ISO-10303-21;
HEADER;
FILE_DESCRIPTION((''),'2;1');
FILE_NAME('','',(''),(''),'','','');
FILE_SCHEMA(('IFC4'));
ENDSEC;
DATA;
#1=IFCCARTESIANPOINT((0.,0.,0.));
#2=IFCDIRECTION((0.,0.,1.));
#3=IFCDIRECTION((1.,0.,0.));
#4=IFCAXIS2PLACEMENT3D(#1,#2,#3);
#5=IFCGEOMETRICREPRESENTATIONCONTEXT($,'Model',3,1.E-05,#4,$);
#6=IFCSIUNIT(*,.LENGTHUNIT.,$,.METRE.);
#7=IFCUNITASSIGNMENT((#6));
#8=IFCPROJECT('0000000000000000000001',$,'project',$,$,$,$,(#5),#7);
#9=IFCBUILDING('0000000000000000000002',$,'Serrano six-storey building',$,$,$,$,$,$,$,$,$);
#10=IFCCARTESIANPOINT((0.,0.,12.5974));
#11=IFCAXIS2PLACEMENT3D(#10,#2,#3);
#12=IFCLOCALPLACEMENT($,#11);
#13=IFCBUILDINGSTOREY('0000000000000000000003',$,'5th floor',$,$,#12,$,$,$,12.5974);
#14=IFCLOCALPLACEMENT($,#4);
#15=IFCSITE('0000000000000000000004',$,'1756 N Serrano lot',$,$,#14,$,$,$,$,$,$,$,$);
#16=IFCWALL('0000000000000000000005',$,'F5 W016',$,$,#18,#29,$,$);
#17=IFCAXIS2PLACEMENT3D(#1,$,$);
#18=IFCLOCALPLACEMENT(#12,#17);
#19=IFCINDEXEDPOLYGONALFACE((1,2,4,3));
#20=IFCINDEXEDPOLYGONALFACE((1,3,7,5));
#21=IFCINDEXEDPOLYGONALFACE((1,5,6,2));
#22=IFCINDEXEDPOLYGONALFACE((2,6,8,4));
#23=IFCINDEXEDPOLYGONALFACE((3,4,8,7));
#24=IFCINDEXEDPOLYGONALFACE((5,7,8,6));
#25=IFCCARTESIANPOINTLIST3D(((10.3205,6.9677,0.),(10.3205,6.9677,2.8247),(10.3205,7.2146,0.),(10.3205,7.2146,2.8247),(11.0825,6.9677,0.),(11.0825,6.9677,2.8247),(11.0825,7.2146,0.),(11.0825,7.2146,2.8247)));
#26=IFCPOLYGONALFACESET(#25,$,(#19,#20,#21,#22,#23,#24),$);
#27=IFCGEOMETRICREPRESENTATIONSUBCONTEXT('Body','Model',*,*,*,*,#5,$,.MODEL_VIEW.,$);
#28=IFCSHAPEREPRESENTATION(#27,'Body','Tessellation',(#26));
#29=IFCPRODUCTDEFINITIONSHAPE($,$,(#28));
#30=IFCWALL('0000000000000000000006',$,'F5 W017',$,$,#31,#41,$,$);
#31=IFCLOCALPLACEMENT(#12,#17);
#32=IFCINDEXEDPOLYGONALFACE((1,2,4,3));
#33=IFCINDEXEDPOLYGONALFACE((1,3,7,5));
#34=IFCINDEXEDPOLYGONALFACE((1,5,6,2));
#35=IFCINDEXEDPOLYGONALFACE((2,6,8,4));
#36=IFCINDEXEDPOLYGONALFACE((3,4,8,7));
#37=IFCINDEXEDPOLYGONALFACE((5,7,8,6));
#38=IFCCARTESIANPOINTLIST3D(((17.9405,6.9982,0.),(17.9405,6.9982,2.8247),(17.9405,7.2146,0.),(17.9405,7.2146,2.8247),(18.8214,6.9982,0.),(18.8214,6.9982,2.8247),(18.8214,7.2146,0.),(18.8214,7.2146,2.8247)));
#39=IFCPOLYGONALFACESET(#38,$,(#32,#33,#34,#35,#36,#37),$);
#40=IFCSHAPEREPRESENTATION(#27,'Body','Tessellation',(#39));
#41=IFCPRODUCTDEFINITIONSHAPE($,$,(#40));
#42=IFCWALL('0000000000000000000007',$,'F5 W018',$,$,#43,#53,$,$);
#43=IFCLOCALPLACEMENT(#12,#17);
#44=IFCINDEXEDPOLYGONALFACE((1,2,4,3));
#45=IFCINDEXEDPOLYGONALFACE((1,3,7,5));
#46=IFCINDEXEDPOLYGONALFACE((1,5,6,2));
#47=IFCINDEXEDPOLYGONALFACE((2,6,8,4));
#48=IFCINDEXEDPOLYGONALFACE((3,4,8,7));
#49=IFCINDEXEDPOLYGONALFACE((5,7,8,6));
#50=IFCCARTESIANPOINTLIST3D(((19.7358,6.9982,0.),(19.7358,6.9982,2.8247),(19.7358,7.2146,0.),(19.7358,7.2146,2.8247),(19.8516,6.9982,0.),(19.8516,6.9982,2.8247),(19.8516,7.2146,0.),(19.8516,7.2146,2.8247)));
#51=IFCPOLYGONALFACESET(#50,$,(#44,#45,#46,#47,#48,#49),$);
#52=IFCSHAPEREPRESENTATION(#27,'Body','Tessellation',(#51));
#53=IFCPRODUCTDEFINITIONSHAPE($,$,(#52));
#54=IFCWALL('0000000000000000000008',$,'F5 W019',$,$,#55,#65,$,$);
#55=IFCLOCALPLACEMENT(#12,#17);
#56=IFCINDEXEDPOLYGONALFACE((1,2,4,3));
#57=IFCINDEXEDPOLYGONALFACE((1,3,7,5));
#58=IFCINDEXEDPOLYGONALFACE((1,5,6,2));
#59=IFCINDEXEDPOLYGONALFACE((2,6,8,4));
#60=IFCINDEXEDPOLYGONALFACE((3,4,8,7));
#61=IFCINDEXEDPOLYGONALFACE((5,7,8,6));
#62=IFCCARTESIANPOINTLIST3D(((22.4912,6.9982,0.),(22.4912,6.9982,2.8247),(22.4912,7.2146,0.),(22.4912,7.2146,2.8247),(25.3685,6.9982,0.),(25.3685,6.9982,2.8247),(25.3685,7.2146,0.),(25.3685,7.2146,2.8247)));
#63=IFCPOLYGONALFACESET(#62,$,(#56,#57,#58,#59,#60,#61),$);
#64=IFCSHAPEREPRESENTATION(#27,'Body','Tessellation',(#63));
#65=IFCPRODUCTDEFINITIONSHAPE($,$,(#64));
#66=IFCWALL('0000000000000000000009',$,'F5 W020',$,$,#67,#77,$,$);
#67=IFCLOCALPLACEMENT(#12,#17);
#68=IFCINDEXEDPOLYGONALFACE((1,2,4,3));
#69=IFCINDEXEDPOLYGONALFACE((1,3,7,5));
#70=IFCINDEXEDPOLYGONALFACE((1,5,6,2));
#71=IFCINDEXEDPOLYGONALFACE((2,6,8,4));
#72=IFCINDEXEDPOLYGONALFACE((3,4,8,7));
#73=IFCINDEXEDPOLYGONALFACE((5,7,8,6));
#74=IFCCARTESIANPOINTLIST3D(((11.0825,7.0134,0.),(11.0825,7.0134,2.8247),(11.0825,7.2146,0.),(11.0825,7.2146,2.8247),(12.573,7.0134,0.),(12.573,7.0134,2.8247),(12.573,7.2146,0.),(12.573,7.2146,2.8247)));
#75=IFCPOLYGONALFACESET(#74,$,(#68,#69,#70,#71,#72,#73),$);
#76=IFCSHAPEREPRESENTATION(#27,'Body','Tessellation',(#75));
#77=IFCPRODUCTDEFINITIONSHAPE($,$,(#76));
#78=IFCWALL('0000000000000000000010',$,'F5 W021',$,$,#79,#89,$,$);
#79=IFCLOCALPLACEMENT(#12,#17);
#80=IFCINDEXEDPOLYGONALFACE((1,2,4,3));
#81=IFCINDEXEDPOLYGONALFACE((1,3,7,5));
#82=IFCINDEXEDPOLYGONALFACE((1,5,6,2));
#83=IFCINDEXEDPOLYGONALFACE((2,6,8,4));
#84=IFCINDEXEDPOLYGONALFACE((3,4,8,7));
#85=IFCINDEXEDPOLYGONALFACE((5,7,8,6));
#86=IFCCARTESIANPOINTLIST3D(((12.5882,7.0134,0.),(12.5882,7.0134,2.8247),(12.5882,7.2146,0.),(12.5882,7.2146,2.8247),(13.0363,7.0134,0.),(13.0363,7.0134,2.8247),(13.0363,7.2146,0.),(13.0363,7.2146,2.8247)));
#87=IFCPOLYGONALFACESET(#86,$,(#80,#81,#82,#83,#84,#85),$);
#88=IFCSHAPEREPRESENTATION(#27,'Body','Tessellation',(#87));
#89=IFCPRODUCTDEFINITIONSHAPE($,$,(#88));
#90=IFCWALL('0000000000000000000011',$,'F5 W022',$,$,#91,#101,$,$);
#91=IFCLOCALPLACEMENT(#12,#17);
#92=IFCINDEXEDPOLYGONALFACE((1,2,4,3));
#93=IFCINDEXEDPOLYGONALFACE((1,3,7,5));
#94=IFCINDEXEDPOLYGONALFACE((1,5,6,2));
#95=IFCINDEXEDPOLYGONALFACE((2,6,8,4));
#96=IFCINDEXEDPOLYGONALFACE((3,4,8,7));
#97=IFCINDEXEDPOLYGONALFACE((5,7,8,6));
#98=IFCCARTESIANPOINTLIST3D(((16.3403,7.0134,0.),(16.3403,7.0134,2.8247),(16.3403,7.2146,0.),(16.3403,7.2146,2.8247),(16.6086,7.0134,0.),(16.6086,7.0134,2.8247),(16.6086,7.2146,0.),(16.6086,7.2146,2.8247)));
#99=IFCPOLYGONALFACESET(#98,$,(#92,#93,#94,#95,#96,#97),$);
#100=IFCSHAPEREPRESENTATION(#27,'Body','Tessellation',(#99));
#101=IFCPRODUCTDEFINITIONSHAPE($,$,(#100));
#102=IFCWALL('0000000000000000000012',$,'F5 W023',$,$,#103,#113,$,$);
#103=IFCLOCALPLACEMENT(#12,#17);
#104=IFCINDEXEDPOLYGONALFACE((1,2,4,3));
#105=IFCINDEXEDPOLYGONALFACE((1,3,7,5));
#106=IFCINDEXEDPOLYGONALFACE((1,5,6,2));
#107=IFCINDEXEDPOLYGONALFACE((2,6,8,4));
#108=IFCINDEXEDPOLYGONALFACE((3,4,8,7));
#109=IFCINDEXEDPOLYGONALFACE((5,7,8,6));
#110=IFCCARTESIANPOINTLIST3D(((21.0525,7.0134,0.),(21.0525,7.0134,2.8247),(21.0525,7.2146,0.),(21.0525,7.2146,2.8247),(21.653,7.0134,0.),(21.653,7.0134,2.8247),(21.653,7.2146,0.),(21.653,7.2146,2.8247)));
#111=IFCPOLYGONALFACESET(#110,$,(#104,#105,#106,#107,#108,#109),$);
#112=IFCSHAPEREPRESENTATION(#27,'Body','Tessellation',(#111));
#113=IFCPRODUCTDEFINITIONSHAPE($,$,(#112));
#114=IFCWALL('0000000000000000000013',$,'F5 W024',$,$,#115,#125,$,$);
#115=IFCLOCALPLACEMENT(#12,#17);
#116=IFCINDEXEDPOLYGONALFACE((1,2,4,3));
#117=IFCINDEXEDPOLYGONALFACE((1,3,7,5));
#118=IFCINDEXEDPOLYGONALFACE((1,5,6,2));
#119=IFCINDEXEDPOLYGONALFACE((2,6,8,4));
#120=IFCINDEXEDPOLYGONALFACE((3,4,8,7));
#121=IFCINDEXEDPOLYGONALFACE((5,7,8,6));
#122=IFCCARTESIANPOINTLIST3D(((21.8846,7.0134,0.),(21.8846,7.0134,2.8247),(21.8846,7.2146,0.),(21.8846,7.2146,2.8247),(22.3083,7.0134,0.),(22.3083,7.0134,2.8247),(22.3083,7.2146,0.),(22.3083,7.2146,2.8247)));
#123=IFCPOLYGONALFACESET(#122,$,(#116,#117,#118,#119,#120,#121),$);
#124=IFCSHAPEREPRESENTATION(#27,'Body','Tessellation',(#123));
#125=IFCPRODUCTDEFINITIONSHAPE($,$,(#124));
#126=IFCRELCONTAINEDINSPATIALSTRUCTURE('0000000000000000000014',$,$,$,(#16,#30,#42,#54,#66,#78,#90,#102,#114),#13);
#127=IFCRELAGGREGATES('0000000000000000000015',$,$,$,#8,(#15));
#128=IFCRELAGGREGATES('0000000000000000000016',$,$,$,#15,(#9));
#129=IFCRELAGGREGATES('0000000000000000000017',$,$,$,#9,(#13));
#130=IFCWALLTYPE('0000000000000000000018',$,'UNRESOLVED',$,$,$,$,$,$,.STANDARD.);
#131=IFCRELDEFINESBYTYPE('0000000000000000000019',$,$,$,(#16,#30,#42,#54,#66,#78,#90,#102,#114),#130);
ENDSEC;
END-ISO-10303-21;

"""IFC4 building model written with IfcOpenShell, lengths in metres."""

from ifc_helpers import new_model, si_unit, frame, origin_with_axes, place, context, subcontext, project, spatial, polyline, outline, extrude, type_object, element, save


model = new_model("IFC4")

# Units and contexts
model_context = context("Model", 3, precision=1e-05, world=origin_with_axes())
body_context = subcontext(model_context, "Body", "Model", "MODEL_VIEW")
ifc_project = project(units=[si_unit("LENGTHUNIT", "METRE")], contexts=[model_context])

# Site, building, storey
site_placement = place(None, origin_with_axes())
site = spatial("IfcSite", under=ifc_project, at=site_placement, Name="1756 N Serrano lot")
building = spatial("IfcBuilding", under=site, Name="Serrano six-storey building")
storey_placement = place(None, frame((0.0, 0.0, 12.5974), z_axis=(0.0, 0.0, 1.0), x_axis=(1.0, 0.0, 0.0)))
storey = spatial("IfcBuildingStorey", under=building, at=storey_placement, Name="5th floor", Elevation=12.5974)

# Walls
wall_type = type_object("IfcWallType", Name="UNRESOLVED", PredefinedType="STANDARD")
wall_1_placement = place(storey_placement, frame((0.0, 0.0, -12.5974), z_axis=(0.0, 0.0, 1.0), x_axis=(1.0, 0.0, 0.0)))
element("IfcWall", 1, at=wall_1_placement, inside=storey, type_object=wall_type, Name="F5 W016", context=body_context, shape_type="SweptSolid", body=[
    extrude(outline(polyline([(11.0825, 7.2146), (11.0825, 6.9677), (10.3205, 6.9677), (10.3205, 7.2146), (11.0825, 7.2146)])), frame((0.0, 0.0, 12.5974)), (0.0, 0.0, 1.0), 2.8247),
])
wall_2_placement = place(storey_placement, frame((0.0, 0.0, -12.5974), z_axis=(0.0, 0.0, 1.0), x_axis=(1.0, 0.0, 0.0)))
element("IfcWall", 2, at=wall_2_placement, inside=storey, type_object=wall_type, Name="F5 W017", context=body_context, shape_type="SweptSolid", body=[
    extrude(outline(polyline([(18.8214, 7.2146), (18.8214, 6.9982), (17.9405, 6.9982), (17.9405, 7.2146), (18.8214, 7.2146)])), frame((0.0, 0.0, 12.5974)), (0.0, 0.0, 1.0), 2.8247),
])
wall_3_placement = place(storey_placement, frame((0.0, 0.0, -12.5974), z_axis=(0.0, 0.0, 1.0), x_axis=(1.0, 0.0, 0.0)))
element("IfcWall", 3, at=wall_3_placement, inside=storey, type_object=wall_type, Name="F5 W018", context=body_context, shape_type="SweptSolid", body=[
    extrude(outline(polyline([(19.8516, 7.2146), (19.8516, 6.9982), (19.7358, 6.9982), (19.7358, 7.2146), (19.8516, 7.2146)])), frame((0.0, 0.0, 12.5974)), (0.0, 0.0, 1.0), 2.8247),
])
wall_4_placement = place(storey_placement, frame((0.0, 0.0, -12.5974), z_axis=(0.0, 0.0, 1.0), x_axis=(1.0, 0.0, 0.0)))
element("IfcWall", 4, at=wall_4_placement, inside=storey, type_object=wall_type, Name="F5 W019", context=body_context, shape_type="SweptSolid", body=[
    extrude(outline(polyline([(25.3685, 7.2146), (25.3685, 6.9982), (22.4912, 6.9982), (22.4912, 7.2146), (25.3685, 7.2146)])), frame((0.0, 0.0, 12.5974)), (0.0, 0.0, 1.0), 2.8247),
])
wall_5_placement = place(storey_placement, frame((0.0, 0.0, -12.5974), z_axis=(0.0, 0.0, 1.0), x_axis=(1.0, 0.0, 0.0)))
element("IfcWall", 5, at=wall_5_placement, inside=storey, type_object=wall_type, Name="F5 W020", context=body_context, shape_type="SweptSolid", body=[
    extrude(outline(polyline([(12.573, 7.2146), (12.573, 7.0134), (11.0825, 7.0134), (11.0825, 7.2146), (12.573, 7.2146)])), frame((0.0, 0.0, 12.5974)), (0.0, 0.0, 1.0), 2.8247),
])
wall_6_placement = place(storey_placement, frame((0.0, 0.0, -12.5974), z_axis=(0.0, 0.0, 1.0), x_axis=(1.0, 0.0, 0.0)))
element("IfcWall", 6, at=wall_6_placement, inside=storey, type_object=wall_type, Name="F5 W021", context=body_context, shape_type="SweptSolid", body=[
    extrude(outline(polyline([(13.0363, 7.2146), (13.0363, 7.0134), (12.5882, 7.0134), (12.5882, 7.2146), (13.0363, 7.2146)])), frame((0.0, 0.0, 12.5974)), (0.0, 0.0, 1.0), 2.8247),
])
wall_7_placement = place(storey_placement, frame((0.0, 0.0, -12.5974), z_axis=(0.0, 0.0, 1.0), x_axis=(1.0, 0.0, 0.0)))
element("IfcWall", 7, at=wall_7_placement, inside=storey, type_object=wall_type, Name="F5 W022", context=body_context, shape_type="SweptSolid", body=[
    extrude(outline(polyline([(16.6086, 7.2146), (16.6086, 7.0134), (16.3403, 7.0134), (16.3403, 7.2146), (16.6086, 7.2146)])), frame((0.0, 0.0, 12.5974)), (0.0, 0.0, 1.0), 2.8247),
])
wall_8_placement = place(storey_placement, frame((0.0, 0.0, -12.5974), z_axis=(0.0, 0.0, 1.0), x_axis=(1.0, 0.0, 0.0)))
element("IfcWall", 8, at=wall_8_placement, inside=storey, type_object=wall_type, Name="F5 W023", context=body_context, shape_type="SweptSolid", body=[
    extrude(outline(polyline([(21.653, 7.2146), (21.653, 7.0134), (21.0525, 7.0134), (21.0525, 7.2146), (21.653, 7.2146)])), frame((0.0, 0.0, 12.5974)), (0.0, 0.0, 1.0), 2.8247),
])
wall_9_placement = place(storey_placement, frame((0.0, 0.0, -12.5974), z_axis=(0.0, 0.0, 1.0), x_axis=(1.0, 0.0, 0.0)))
element("IfcWall", 9, at=wall_9_placement, inside=storey, type_object=wall_type, Name="F5 W024", context=body_context, shape_type="SweptSolid", body=[
    extrude(outline(polyline([(22.3083, 7.2146), (22.3083, 7.0134), (21.8846, 7.0134), (21.8846, 7.2146), (22.3083, 7.2146)])), frame((0.0, 0.0, 12.5974)), (0.0, 0.0, 1.0), 2.8247),
])

save(model, "model.ifc")
